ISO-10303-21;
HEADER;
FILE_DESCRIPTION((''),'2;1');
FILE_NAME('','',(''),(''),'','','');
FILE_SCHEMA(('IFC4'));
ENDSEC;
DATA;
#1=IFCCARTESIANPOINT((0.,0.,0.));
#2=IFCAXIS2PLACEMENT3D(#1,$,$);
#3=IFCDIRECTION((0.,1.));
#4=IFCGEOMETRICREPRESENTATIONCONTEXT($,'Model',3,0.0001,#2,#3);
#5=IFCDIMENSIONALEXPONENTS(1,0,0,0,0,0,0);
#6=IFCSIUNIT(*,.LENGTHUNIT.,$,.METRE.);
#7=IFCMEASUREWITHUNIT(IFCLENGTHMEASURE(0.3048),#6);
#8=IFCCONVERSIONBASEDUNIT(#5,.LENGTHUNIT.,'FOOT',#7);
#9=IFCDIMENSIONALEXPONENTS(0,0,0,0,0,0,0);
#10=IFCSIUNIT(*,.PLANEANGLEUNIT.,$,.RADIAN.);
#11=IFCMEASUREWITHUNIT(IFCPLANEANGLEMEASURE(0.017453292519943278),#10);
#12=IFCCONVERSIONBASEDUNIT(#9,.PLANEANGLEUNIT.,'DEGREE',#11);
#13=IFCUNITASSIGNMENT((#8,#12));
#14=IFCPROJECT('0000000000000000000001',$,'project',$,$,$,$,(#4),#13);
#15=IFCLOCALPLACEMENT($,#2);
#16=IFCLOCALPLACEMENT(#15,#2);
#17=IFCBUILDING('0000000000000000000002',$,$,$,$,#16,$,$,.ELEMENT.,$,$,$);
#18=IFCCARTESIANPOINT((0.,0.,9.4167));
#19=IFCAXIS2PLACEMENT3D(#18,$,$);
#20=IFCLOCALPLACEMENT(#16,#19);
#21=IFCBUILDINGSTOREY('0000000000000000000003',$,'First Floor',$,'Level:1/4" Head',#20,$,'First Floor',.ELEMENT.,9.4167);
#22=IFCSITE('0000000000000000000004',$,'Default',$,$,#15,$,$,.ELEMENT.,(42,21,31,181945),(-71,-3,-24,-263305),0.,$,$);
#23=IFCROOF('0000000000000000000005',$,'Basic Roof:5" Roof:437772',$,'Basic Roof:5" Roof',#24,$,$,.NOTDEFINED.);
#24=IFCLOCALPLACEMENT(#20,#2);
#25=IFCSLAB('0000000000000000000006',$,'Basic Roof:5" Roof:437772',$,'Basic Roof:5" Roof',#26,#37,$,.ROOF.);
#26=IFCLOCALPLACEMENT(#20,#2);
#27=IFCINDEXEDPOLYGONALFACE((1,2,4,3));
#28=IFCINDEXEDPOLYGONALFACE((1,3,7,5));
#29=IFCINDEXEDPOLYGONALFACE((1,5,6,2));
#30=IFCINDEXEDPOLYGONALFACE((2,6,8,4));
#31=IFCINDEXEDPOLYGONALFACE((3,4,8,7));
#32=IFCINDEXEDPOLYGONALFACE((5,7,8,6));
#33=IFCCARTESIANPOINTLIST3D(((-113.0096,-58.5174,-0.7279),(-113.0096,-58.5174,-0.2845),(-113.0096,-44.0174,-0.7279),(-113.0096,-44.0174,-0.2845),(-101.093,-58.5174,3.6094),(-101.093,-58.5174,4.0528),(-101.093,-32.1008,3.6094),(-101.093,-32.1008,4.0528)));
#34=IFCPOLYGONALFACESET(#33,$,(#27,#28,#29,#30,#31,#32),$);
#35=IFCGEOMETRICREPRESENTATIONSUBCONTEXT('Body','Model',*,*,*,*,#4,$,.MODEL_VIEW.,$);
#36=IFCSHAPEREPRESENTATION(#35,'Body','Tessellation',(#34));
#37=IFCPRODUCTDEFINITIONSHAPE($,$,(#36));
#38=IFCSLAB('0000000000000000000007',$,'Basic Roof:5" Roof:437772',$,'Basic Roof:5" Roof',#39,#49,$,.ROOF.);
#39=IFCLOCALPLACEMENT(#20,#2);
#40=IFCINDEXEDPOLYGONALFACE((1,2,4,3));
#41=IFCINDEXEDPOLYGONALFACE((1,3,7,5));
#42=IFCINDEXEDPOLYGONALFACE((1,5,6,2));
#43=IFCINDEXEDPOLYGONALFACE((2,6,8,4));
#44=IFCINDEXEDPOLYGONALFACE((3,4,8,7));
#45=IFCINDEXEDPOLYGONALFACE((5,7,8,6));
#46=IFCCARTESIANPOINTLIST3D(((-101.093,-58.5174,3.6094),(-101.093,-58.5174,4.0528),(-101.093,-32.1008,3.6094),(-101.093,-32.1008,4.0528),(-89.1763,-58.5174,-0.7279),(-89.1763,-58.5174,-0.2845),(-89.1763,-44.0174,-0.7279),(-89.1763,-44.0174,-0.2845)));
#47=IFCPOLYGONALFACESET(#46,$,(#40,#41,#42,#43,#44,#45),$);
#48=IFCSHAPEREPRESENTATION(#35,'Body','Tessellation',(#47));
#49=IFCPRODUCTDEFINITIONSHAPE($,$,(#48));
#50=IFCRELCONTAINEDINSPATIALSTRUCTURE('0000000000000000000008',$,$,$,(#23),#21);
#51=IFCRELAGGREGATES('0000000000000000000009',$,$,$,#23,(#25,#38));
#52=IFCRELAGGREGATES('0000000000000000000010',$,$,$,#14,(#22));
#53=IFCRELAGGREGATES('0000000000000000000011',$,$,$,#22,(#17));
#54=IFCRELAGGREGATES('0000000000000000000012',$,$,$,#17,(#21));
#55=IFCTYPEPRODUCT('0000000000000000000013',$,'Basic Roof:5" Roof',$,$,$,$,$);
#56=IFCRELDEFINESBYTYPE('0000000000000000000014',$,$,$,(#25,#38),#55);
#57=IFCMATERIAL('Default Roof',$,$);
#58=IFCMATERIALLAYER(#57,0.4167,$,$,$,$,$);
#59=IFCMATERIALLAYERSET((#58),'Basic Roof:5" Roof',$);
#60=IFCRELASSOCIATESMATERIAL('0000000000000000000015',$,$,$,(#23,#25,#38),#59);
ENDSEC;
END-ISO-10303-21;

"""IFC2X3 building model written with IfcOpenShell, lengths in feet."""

from ifc_helpers import new_model, entity, si_unit, converted_unit, direction, frame, origin, place, context, subcontext, project, spatial, polyline, outline, extrude, material, layer, layer_set, type_object, element, aggregate, save


model = new_model("IFC2X3")

# Units and contexts
model_context = context("Model", 3, precision=0.0001, world=origin(), true_north=direction((0.0, 1.0)))
body_context = subcontext(model_context, "Body", "Model", "MODEL_VIEW")
ifc_project = project(units=[converted_unit("LENGTHUNIT", "FOOT", entity("IfcLengthMeasure", 0.3048), si_unit("LENGTHUNIT", "METRE"), dimensions=[1, 0, 0, 0, 0, 0, 0]), converted_unit("PLANEANGLEUNIT", "DEGREE", entity("IfcPlaneAngleMeasure", 0.017453292519943278), si_unit("PLANEANGLEUNIT", "RADIAN"), dimensions=[0, 0, 0, 0, 0, 0, 0])], contexts=[model_context])

# Site, building, storey
site_placement = place(None, origin())
site = spatial("IfcSite", under=ifc_project, at=site_placement, Name="Default", CompositionType="ELEMENT", RefLatitude=(42, 21, 31, 181945), RefLongitude=(-71, -3, -24, -263305), RefElevation=0.0)
building_placement = place(site_placement, origin())
building = spatial("IfcBuilding", under=site, at=building_placement, CompositionType="ELEMENT")
storey_placement = place(building_placement, frame((0.0, 0.0, 9.4167)))
storey = spatial("IfcBuildingStorey", under=building, at=storey_placement, Name="First Floor", ObjectType="Level:1/4\" Head", LongName="First Floor", CompositionType="ELEMENT", Elevation=9.4167)

# Roof, slabs
ifc_material_1 = material(Name="Default Roof")
ifc_layer = layer(ifc_material_1, 0.4167)
ifc_layer_set = layer_set([ifc_layer], Name="Basic Roof:5\" Roof")
roof_placement = place(storey_placement, frame((-131.0096, -58.5174, -0.7279)))
roof = element("IfcRoof", 1, at=roof_placement, inside=storey, material=ifc_layer_set, Name="Basic Roof:5\" Roof:437772", ObjectType="Basic Roof:5\" Roof", ShapeType="NOTDEFINED")
type_product = type_object("IfcTypeProduct", Name="Basic Roof:5\" Roof")
slab_1_placement = place(roof_placement, origin())
slab_1 = element("IfcSlab", 2, at=slab_1_placement, type_object=type_product, material=ifc_layer_set, Name="Basic Roof:5\" Roof:437772", ObjectType="Basic Roof:5\" Roof", PredefinedType="ROOF", context=body_context, shape_type="SweptSolid", body=[
    extrude(outline(polyline([(-6.3407, -13.2083), (6.3407, -13.2083), (6.3407, 13.2083), (-6.3407, 1.2917), (-6.3407, -13.2083)])), frame((23.9583, 13.2083, 2.1687), z_axis=(-0.34202, 0.0, 0.939693), x_axis=(0.939693, 0.0, 0.34202)), (0.34202, 0.0, 0.939693), 0.4434),
])
slab_2_placement = place(roof_placement, origin())
slab_2 = element("IfcSlab", 3, at=slab_2_placement, type_object=type_product, material=ifc_layer_set, Name="Basic Roof:5\" Roof:437772", ObjectType="Basic Roof:5\" Roof", PredefinedType="ROOF", context=body_context, shape_type="SweptSolid", body=[
    extrude(outline(polyline([(6.3407, -13.2083), (6.3407, 1.2917), (-6.3407, 13.2083), (-6.3407, -13.2083), (6.3407, -13.2083)])), frame((35.875, 13.2083, 2.1687), z_axis=(0.34202, 0.0, 0.939693), x_axis=(0.939693, 0.0, -0.34202)), (-0.34202, 0.0, 0.939693), 0.4434),
])
aggregate(roof, [slab_1, slab_2])

save(model, "model.ifc")
